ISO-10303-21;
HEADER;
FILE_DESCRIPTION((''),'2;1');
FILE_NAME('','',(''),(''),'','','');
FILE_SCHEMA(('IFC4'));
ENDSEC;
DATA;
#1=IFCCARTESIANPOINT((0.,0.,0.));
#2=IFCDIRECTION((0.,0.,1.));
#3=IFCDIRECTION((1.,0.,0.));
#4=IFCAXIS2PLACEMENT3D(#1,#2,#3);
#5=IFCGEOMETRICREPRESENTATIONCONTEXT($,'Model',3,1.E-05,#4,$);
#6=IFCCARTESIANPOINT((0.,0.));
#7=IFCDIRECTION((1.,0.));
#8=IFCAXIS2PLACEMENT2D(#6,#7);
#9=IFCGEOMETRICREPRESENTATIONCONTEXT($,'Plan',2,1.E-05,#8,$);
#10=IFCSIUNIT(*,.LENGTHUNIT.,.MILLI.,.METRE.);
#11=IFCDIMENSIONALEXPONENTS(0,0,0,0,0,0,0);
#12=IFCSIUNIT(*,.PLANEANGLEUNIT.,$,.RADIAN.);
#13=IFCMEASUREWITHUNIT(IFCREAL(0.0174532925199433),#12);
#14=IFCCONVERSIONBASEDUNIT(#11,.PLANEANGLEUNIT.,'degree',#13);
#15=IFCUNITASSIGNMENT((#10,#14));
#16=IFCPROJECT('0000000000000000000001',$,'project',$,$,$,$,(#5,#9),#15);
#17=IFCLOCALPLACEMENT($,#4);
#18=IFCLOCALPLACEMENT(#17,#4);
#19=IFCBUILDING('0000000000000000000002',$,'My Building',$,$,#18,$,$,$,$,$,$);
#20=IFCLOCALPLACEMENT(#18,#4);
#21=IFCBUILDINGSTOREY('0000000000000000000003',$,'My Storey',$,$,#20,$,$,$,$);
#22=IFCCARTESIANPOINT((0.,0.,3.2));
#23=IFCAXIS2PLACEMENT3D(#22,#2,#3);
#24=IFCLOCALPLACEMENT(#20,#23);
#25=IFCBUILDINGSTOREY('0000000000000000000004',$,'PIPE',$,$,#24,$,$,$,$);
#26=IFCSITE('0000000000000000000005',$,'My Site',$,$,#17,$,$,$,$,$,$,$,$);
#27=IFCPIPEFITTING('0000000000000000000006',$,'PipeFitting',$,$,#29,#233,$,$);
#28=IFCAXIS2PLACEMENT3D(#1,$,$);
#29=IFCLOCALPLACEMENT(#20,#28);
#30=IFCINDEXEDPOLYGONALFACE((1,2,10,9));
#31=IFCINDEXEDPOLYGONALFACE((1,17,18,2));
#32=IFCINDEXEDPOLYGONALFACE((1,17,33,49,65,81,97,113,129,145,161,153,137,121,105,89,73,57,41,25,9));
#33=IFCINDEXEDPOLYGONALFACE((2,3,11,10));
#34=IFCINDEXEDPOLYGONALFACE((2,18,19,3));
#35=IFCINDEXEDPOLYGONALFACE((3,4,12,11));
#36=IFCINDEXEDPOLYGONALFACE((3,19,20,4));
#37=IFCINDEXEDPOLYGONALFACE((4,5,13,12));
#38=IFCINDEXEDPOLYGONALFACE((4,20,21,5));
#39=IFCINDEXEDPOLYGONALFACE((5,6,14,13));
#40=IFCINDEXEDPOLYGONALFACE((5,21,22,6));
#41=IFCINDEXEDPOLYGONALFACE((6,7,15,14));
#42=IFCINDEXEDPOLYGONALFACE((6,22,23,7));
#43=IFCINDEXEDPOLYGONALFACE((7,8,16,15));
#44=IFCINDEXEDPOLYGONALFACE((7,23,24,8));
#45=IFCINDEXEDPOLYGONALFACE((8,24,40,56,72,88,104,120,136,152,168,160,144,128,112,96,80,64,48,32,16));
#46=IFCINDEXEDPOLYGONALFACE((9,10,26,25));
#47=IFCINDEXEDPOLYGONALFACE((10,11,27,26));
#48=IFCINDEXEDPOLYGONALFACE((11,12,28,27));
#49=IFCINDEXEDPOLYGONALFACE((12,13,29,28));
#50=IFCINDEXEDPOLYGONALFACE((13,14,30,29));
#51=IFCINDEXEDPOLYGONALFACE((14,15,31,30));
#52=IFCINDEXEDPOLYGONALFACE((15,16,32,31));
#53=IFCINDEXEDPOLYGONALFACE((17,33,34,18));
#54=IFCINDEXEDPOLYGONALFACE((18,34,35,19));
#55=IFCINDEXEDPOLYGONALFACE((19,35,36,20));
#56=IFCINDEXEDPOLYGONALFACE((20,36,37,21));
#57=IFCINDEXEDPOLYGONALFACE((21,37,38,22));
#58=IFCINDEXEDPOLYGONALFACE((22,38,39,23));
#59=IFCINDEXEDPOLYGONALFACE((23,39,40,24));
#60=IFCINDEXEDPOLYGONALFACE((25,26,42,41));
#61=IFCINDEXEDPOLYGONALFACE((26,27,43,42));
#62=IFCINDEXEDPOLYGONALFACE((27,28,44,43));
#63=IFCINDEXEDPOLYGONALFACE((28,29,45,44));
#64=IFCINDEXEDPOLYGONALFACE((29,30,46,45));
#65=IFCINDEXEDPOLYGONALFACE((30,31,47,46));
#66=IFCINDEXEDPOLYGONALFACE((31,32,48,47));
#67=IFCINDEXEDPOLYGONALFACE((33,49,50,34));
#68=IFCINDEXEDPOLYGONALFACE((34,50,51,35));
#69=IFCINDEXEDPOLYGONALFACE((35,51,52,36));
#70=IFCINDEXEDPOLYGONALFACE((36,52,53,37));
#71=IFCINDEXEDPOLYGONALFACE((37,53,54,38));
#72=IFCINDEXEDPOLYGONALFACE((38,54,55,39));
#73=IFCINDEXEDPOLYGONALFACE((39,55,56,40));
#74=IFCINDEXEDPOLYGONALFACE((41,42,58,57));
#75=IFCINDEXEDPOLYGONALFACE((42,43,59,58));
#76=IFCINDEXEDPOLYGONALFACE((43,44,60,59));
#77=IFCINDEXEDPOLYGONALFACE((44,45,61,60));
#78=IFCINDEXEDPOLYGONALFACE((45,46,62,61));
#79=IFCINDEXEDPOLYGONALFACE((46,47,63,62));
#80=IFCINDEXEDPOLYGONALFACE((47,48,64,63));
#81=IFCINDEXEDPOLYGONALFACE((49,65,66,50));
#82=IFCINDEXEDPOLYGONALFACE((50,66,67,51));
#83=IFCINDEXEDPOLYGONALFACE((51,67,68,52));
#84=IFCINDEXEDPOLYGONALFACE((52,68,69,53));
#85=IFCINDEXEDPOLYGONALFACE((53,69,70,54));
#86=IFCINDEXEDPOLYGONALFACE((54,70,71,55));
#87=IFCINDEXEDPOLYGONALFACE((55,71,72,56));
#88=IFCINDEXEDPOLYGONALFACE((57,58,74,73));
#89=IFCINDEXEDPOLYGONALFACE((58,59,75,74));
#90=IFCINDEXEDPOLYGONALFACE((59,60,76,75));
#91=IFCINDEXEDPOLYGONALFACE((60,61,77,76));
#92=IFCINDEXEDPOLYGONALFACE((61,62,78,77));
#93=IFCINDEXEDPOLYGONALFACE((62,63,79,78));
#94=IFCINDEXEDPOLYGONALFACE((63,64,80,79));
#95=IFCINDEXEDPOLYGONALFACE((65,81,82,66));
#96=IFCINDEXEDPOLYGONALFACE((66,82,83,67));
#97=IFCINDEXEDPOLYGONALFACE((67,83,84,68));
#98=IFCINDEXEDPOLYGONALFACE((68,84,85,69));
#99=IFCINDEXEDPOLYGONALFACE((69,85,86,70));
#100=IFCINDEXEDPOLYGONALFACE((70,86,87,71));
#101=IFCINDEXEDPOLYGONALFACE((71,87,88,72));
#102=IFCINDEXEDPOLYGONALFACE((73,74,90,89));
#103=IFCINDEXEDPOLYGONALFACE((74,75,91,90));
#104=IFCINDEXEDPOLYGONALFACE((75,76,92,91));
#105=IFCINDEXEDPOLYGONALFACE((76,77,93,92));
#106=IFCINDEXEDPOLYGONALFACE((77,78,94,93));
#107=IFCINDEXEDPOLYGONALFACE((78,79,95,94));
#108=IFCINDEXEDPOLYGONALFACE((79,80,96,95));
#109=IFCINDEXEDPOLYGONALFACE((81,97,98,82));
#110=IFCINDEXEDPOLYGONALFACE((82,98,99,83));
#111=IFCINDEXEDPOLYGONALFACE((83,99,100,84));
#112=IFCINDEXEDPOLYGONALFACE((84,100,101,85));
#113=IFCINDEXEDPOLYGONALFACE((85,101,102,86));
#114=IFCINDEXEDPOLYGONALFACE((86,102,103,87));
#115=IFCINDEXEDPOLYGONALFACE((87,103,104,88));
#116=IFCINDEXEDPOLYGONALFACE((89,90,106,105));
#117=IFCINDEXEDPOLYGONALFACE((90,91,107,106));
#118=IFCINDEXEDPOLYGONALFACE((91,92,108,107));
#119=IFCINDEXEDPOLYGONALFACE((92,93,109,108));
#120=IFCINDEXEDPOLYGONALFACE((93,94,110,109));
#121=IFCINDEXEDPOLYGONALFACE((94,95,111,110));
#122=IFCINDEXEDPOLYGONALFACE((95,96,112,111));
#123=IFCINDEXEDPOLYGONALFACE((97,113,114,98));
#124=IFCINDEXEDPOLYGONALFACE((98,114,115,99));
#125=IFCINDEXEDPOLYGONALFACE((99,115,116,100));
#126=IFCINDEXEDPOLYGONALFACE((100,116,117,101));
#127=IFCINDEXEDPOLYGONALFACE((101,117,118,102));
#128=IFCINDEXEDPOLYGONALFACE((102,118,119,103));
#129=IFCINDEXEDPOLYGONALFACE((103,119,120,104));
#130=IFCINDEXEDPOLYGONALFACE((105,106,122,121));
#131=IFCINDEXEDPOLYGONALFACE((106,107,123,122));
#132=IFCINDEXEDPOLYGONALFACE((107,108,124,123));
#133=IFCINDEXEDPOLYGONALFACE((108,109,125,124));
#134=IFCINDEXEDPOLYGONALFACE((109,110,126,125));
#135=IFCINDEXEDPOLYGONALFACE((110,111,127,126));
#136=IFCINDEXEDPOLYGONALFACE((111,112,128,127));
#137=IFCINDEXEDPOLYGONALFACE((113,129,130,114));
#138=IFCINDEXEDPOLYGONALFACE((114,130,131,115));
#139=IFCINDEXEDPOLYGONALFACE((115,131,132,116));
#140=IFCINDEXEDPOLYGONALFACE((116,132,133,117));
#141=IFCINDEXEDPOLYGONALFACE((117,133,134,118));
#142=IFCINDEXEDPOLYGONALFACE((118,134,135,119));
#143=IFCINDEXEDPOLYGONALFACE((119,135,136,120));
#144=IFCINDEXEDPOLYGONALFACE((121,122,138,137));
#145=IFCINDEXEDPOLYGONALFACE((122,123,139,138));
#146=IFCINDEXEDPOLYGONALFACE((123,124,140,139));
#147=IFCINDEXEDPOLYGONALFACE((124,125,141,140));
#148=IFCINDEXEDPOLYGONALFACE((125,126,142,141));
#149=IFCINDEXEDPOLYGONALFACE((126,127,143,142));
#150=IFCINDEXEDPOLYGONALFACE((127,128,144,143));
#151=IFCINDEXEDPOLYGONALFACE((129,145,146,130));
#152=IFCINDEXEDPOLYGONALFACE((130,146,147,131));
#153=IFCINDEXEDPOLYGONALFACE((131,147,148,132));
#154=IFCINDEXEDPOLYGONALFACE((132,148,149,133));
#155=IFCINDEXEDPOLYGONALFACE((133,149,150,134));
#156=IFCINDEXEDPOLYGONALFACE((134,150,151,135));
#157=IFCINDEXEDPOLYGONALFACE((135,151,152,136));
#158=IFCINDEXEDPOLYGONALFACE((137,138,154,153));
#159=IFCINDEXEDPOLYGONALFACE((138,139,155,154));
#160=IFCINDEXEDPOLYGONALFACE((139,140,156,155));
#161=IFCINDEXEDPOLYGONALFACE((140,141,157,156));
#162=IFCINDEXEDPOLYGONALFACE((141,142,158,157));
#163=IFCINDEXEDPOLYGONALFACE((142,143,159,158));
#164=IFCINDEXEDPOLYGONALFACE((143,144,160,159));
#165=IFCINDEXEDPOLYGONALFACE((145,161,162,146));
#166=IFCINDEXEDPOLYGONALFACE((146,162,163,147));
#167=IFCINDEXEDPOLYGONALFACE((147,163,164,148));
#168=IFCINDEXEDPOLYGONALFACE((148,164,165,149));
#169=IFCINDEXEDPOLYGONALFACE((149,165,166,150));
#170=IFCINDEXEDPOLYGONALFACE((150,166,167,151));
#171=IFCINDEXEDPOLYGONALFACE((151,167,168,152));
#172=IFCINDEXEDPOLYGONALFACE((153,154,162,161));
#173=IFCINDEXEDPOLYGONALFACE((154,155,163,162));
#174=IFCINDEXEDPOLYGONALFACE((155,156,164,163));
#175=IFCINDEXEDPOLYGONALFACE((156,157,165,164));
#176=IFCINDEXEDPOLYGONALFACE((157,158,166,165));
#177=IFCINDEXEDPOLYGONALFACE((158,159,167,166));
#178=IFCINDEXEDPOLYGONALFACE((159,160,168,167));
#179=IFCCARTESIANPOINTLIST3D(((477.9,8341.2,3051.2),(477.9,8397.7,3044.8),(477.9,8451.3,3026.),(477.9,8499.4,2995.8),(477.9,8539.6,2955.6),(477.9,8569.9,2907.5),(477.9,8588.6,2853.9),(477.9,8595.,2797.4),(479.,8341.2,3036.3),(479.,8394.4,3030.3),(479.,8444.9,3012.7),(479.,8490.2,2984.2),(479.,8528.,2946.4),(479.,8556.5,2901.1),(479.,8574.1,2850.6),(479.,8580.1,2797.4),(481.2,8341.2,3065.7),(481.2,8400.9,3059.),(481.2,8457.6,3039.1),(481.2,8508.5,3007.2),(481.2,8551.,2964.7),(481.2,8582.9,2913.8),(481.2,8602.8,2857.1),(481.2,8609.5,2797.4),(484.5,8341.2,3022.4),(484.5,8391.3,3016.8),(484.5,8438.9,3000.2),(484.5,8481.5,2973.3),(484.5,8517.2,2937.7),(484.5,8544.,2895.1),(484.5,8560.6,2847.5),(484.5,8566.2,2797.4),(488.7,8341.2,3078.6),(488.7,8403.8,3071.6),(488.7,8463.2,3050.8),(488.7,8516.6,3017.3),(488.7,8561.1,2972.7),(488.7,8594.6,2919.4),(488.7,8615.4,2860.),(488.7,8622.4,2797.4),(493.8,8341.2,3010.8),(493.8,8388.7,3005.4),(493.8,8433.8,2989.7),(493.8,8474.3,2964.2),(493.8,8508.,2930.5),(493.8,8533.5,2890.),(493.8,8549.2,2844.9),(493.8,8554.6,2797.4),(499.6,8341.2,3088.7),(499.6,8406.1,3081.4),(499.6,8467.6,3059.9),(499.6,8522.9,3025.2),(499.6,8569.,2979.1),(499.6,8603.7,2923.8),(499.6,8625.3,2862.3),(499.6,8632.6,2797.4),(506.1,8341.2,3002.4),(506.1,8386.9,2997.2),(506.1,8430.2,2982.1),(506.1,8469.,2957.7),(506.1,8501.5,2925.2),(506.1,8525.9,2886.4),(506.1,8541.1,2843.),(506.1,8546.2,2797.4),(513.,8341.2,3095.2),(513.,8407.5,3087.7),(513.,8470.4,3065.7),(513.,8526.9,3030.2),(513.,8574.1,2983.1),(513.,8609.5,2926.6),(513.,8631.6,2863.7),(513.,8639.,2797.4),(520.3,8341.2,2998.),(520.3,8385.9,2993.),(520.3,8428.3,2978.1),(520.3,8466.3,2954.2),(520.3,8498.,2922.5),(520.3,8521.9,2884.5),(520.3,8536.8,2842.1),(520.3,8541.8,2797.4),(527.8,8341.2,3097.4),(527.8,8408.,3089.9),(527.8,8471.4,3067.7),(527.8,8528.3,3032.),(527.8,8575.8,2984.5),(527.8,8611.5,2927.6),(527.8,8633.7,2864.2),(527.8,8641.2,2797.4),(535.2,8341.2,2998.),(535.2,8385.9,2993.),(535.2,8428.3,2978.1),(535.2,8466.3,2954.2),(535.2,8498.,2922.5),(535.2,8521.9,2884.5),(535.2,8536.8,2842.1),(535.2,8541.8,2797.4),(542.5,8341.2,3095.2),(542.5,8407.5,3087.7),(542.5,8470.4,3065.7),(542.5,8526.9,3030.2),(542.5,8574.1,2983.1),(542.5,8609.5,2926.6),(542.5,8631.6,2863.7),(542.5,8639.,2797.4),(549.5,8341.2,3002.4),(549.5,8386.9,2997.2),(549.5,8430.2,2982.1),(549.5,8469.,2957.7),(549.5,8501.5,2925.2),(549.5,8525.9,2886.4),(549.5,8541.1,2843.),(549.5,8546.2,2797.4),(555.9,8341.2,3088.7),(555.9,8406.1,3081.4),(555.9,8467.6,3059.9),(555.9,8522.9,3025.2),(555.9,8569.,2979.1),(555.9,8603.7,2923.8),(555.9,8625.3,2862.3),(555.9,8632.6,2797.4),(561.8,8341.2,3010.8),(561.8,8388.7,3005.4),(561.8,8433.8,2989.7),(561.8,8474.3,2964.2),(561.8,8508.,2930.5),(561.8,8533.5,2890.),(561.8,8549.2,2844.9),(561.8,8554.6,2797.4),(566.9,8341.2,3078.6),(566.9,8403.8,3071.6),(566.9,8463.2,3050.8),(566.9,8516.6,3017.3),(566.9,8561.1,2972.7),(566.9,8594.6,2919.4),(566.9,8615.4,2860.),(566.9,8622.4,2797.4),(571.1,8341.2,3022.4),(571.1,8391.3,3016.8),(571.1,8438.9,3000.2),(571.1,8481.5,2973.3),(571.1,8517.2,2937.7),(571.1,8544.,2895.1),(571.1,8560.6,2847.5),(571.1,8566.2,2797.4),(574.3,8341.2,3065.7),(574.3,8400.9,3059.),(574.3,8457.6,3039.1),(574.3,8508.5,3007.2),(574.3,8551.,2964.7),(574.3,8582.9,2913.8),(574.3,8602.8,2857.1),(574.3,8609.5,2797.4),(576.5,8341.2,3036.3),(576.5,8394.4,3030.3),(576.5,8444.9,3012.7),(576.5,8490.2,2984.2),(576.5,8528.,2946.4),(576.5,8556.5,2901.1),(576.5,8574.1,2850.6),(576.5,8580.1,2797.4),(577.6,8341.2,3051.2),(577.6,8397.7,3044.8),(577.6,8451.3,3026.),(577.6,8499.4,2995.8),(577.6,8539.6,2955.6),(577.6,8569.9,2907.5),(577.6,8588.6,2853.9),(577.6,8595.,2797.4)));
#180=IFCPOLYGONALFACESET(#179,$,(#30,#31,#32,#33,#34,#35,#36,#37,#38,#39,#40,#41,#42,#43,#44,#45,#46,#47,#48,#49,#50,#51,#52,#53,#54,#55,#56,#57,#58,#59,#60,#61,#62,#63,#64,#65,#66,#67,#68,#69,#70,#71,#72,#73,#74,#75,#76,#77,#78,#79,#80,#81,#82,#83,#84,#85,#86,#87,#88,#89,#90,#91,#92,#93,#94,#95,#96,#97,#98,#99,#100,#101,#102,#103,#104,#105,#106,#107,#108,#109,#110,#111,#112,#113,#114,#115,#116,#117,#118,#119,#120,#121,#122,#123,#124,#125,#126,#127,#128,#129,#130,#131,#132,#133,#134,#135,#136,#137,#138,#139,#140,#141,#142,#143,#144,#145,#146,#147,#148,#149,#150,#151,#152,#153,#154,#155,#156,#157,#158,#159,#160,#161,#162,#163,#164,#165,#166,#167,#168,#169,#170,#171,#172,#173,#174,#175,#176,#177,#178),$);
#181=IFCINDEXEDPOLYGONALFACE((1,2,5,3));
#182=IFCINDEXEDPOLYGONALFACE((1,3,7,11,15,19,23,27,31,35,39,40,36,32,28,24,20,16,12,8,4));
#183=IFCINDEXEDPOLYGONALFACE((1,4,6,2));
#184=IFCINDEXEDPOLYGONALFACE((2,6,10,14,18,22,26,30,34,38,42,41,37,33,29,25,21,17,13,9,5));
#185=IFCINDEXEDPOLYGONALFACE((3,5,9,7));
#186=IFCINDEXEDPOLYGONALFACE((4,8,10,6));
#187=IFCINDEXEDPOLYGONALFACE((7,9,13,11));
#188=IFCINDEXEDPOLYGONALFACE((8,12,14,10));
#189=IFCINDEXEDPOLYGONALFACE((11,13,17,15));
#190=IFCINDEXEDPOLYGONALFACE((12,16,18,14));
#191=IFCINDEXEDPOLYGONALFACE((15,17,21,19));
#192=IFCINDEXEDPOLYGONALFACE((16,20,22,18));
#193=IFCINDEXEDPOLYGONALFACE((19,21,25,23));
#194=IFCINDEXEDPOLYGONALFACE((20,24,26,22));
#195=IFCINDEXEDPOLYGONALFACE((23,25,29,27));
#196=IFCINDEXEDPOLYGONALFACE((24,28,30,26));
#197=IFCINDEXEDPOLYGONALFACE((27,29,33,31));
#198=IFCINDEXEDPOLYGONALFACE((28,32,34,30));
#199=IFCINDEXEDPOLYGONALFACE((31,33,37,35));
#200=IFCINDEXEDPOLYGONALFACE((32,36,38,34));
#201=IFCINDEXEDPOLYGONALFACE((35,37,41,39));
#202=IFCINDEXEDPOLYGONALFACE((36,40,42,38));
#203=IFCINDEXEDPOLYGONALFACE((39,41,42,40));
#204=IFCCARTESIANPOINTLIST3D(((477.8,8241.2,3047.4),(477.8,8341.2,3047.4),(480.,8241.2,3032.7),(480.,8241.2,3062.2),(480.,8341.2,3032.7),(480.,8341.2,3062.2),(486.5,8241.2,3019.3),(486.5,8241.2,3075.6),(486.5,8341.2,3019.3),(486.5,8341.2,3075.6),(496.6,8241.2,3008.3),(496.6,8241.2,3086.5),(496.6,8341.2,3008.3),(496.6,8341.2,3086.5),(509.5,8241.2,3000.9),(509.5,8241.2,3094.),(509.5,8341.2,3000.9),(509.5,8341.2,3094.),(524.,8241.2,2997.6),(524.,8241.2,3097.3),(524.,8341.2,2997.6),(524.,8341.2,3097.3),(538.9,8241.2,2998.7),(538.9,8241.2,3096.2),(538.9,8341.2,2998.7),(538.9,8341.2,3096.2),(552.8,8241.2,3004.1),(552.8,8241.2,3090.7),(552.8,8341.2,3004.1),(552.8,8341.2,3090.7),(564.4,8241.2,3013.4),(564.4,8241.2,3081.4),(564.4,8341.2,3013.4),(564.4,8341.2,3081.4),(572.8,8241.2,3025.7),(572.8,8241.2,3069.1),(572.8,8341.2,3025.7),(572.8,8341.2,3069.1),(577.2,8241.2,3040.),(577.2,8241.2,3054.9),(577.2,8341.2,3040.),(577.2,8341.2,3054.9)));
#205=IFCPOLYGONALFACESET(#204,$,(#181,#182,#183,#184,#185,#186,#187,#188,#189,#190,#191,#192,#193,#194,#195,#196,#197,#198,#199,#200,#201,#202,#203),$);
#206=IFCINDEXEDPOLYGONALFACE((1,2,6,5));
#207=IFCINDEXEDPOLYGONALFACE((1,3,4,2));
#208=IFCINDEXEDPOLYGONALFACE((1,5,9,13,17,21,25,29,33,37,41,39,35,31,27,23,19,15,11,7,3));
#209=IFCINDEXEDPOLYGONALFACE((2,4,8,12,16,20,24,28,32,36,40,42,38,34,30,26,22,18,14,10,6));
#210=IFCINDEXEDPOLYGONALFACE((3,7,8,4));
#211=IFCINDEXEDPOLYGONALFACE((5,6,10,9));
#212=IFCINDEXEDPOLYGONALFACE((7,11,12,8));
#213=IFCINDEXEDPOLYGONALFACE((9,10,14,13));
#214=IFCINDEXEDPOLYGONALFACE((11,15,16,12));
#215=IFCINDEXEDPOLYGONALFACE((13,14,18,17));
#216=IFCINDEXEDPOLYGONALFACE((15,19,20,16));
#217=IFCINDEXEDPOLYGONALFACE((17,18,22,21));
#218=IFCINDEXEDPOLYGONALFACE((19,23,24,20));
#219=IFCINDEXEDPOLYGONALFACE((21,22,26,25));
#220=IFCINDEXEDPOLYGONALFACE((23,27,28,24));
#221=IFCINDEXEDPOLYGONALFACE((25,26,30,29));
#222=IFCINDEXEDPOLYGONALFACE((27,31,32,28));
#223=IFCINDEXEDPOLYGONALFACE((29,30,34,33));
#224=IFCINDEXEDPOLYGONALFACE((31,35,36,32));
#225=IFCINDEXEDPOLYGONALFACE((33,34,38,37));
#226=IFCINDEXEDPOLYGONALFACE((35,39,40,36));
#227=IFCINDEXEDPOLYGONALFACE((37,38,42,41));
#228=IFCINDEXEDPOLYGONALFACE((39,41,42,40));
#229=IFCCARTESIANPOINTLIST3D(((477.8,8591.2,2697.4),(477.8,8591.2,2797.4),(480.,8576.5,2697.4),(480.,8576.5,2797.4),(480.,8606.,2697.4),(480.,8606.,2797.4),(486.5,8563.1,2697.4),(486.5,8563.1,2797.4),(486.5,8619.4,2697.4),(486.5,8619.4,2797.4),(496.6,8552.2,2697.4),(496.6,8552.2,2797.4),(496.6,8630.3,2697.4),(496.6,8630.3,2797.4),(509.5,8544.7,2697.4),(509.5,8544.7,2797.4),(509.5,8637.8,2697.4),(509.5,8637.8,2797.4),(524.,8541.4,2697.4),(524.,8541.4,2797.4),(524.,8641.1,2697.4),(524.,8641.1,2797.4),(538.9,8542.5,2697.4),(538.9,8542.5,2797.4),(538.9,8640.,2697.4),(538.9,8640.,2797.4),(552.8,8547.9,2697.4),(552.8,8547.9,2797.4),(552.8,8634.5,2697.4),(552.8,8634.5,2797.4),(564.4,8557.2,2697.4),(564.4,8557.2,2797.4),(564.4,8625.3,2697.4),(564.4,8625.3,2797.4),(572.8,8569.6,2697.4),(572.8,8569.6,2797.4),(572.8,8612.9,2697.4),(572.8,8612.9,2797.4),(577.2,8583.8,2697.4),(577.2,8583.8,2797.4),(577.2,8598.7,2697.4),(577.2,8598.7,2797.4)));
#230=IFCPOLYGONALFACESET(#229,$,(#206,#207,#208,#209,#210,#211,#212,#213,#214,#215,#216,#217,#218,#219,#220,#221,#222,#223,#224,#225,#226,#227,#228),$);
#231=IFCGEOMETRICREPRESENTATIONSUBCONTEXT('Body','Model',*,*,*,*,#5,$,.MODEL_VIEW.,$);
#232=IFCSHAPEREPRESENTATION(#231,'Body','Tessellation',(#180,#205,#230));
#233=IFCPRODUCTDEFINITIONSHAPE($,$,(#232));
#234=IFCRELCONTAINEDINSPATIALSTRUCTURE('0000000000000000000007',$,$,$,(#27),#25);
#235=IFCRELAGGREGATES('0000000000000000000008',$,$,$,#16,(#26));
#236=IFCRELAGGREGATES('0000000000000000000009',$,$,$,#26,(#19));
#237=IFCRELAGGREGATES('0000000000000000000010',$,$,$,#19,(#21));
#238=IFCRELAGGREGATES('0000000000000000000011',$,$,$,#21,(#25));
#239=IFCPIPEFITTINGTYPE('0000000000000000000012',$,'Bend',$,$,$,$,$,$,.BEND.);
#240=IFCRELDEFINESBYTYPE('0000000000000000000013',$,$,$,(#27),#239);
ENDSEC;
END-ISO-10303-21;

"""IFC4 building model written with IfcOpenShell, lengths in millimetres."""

from ifc_helpers import new_model, entity, si_unit, converted_unit, frame, origin_with_axes, origin_2d_with_axis, place, context, subcontext, project, spatial, circle, extrude, source, transform, mapped, type_object, type_shapes, element, save


model = new_model("IFC4")

# Units and contexts
model_context = context("Model", 3, precision=1e-05, world=origin_with_axes())
plan_context = context("Plan", 2, precision=1e-05, world=origin_2d_with_axis())
body_context = subcontext(model_context, "Body", "Model", "MODEL_VIEW")
ifc_project = project(units=[si_unit("LENGTHUNIT", "METRE", prefix="MILLI"), converted_unit("PLANEANGLEUNIT", "degree", entity("IfcReal", 0.0174532925199433), si_unit("PLANEANGLEUNIT", "RADIAN"), dimensions=[0, 0, 0, 0, 0, 0, 0])], contexts=[model_context, plan_context])

# Site, building, storeys
site_placement = place(None, origin_with_axes())
site = spatial("IfcSite", under=ifc_project, at=site_placement, Name="My Site")
building_placement = place(site_placement, origin_with_axes())
building = spatial("IfcBuilding", under=site, at=building_placement, Name="My Building")
storey_1_placement = place(building_placement, origin_with_axes())
storey_1 = spatial("IfcBuildingStorey", under=building, at=storey_1_placement, Name="My Storey")
storey_2_placement = place(storey_1_placement, frame((0.0, 0.0, 3.2), z_axis=(0.0, 0.0, 1.0), x_axis=(1.0, 0.0, 0.0)))
storey_2 = spatial("IfcBuildingStorey", under=storey_1, at=storey_2_placement, Name="PIPE")

# Pipe fitting
pipe_fitting_type = type_object("IfcPipeFittingType", Name="Bend", PredefinedType="BEND")
shared_shape = source(origin_with_axes(), body_context, "Body", "SolidModel", [
    entity("IfcSweptDiskSolid", entity("IfcIndexedPolyCurve", entity("IfcCartesianPointList3D", [[0.0, 0.0, 100.0], [0.0, -73.2, 276.8], [0.0, -250.0, 350.0]]), [entity("IfcArcIndex", [1, 2, 3])]), 50.0),
    extrude(circle(Radius=50.0), origin_with_axes(), (0.0, 0.0, 1.0), 100.0),
    extrude(circle(Radius=50.0), frame((0.0, -250.0, 350.0), z_axis=(0.0, -1.0, 0.0), x_axis=(1.0, 0.0, 0.0)), (0.0, 0.0, 1.0), 100.0),
])
type_shapes(pipe_fitting_type, [shared_shape])
for number, where, z_axis, x_axis, name in (
    (1, (527.8, 8241.2, 3044.2), (0.0, 1.0, 0.0), (-1.0, 0.0, 0.0), "PipeFitting"),
):
    element("IfcPipeFitting", number, at=place(storey_2_placement, frame(where, z_axis=z_axis, x_axis=x_axis)), inside=storey_2, type_object=pipe_fitting_type, Name=name, context=body_context, shape_type="MappedRepresentation", body=[
        mapped(shared_shape, transform((0.0, 0.0, 0.0), x_axis=(1.0, 0.0, 0.0), y_axis=(0.0, 1.0, 0.0), z_axis=(0.0, 0.0, 1.0), scale=1.0)),
    ])

save(model, "model.ifc")
